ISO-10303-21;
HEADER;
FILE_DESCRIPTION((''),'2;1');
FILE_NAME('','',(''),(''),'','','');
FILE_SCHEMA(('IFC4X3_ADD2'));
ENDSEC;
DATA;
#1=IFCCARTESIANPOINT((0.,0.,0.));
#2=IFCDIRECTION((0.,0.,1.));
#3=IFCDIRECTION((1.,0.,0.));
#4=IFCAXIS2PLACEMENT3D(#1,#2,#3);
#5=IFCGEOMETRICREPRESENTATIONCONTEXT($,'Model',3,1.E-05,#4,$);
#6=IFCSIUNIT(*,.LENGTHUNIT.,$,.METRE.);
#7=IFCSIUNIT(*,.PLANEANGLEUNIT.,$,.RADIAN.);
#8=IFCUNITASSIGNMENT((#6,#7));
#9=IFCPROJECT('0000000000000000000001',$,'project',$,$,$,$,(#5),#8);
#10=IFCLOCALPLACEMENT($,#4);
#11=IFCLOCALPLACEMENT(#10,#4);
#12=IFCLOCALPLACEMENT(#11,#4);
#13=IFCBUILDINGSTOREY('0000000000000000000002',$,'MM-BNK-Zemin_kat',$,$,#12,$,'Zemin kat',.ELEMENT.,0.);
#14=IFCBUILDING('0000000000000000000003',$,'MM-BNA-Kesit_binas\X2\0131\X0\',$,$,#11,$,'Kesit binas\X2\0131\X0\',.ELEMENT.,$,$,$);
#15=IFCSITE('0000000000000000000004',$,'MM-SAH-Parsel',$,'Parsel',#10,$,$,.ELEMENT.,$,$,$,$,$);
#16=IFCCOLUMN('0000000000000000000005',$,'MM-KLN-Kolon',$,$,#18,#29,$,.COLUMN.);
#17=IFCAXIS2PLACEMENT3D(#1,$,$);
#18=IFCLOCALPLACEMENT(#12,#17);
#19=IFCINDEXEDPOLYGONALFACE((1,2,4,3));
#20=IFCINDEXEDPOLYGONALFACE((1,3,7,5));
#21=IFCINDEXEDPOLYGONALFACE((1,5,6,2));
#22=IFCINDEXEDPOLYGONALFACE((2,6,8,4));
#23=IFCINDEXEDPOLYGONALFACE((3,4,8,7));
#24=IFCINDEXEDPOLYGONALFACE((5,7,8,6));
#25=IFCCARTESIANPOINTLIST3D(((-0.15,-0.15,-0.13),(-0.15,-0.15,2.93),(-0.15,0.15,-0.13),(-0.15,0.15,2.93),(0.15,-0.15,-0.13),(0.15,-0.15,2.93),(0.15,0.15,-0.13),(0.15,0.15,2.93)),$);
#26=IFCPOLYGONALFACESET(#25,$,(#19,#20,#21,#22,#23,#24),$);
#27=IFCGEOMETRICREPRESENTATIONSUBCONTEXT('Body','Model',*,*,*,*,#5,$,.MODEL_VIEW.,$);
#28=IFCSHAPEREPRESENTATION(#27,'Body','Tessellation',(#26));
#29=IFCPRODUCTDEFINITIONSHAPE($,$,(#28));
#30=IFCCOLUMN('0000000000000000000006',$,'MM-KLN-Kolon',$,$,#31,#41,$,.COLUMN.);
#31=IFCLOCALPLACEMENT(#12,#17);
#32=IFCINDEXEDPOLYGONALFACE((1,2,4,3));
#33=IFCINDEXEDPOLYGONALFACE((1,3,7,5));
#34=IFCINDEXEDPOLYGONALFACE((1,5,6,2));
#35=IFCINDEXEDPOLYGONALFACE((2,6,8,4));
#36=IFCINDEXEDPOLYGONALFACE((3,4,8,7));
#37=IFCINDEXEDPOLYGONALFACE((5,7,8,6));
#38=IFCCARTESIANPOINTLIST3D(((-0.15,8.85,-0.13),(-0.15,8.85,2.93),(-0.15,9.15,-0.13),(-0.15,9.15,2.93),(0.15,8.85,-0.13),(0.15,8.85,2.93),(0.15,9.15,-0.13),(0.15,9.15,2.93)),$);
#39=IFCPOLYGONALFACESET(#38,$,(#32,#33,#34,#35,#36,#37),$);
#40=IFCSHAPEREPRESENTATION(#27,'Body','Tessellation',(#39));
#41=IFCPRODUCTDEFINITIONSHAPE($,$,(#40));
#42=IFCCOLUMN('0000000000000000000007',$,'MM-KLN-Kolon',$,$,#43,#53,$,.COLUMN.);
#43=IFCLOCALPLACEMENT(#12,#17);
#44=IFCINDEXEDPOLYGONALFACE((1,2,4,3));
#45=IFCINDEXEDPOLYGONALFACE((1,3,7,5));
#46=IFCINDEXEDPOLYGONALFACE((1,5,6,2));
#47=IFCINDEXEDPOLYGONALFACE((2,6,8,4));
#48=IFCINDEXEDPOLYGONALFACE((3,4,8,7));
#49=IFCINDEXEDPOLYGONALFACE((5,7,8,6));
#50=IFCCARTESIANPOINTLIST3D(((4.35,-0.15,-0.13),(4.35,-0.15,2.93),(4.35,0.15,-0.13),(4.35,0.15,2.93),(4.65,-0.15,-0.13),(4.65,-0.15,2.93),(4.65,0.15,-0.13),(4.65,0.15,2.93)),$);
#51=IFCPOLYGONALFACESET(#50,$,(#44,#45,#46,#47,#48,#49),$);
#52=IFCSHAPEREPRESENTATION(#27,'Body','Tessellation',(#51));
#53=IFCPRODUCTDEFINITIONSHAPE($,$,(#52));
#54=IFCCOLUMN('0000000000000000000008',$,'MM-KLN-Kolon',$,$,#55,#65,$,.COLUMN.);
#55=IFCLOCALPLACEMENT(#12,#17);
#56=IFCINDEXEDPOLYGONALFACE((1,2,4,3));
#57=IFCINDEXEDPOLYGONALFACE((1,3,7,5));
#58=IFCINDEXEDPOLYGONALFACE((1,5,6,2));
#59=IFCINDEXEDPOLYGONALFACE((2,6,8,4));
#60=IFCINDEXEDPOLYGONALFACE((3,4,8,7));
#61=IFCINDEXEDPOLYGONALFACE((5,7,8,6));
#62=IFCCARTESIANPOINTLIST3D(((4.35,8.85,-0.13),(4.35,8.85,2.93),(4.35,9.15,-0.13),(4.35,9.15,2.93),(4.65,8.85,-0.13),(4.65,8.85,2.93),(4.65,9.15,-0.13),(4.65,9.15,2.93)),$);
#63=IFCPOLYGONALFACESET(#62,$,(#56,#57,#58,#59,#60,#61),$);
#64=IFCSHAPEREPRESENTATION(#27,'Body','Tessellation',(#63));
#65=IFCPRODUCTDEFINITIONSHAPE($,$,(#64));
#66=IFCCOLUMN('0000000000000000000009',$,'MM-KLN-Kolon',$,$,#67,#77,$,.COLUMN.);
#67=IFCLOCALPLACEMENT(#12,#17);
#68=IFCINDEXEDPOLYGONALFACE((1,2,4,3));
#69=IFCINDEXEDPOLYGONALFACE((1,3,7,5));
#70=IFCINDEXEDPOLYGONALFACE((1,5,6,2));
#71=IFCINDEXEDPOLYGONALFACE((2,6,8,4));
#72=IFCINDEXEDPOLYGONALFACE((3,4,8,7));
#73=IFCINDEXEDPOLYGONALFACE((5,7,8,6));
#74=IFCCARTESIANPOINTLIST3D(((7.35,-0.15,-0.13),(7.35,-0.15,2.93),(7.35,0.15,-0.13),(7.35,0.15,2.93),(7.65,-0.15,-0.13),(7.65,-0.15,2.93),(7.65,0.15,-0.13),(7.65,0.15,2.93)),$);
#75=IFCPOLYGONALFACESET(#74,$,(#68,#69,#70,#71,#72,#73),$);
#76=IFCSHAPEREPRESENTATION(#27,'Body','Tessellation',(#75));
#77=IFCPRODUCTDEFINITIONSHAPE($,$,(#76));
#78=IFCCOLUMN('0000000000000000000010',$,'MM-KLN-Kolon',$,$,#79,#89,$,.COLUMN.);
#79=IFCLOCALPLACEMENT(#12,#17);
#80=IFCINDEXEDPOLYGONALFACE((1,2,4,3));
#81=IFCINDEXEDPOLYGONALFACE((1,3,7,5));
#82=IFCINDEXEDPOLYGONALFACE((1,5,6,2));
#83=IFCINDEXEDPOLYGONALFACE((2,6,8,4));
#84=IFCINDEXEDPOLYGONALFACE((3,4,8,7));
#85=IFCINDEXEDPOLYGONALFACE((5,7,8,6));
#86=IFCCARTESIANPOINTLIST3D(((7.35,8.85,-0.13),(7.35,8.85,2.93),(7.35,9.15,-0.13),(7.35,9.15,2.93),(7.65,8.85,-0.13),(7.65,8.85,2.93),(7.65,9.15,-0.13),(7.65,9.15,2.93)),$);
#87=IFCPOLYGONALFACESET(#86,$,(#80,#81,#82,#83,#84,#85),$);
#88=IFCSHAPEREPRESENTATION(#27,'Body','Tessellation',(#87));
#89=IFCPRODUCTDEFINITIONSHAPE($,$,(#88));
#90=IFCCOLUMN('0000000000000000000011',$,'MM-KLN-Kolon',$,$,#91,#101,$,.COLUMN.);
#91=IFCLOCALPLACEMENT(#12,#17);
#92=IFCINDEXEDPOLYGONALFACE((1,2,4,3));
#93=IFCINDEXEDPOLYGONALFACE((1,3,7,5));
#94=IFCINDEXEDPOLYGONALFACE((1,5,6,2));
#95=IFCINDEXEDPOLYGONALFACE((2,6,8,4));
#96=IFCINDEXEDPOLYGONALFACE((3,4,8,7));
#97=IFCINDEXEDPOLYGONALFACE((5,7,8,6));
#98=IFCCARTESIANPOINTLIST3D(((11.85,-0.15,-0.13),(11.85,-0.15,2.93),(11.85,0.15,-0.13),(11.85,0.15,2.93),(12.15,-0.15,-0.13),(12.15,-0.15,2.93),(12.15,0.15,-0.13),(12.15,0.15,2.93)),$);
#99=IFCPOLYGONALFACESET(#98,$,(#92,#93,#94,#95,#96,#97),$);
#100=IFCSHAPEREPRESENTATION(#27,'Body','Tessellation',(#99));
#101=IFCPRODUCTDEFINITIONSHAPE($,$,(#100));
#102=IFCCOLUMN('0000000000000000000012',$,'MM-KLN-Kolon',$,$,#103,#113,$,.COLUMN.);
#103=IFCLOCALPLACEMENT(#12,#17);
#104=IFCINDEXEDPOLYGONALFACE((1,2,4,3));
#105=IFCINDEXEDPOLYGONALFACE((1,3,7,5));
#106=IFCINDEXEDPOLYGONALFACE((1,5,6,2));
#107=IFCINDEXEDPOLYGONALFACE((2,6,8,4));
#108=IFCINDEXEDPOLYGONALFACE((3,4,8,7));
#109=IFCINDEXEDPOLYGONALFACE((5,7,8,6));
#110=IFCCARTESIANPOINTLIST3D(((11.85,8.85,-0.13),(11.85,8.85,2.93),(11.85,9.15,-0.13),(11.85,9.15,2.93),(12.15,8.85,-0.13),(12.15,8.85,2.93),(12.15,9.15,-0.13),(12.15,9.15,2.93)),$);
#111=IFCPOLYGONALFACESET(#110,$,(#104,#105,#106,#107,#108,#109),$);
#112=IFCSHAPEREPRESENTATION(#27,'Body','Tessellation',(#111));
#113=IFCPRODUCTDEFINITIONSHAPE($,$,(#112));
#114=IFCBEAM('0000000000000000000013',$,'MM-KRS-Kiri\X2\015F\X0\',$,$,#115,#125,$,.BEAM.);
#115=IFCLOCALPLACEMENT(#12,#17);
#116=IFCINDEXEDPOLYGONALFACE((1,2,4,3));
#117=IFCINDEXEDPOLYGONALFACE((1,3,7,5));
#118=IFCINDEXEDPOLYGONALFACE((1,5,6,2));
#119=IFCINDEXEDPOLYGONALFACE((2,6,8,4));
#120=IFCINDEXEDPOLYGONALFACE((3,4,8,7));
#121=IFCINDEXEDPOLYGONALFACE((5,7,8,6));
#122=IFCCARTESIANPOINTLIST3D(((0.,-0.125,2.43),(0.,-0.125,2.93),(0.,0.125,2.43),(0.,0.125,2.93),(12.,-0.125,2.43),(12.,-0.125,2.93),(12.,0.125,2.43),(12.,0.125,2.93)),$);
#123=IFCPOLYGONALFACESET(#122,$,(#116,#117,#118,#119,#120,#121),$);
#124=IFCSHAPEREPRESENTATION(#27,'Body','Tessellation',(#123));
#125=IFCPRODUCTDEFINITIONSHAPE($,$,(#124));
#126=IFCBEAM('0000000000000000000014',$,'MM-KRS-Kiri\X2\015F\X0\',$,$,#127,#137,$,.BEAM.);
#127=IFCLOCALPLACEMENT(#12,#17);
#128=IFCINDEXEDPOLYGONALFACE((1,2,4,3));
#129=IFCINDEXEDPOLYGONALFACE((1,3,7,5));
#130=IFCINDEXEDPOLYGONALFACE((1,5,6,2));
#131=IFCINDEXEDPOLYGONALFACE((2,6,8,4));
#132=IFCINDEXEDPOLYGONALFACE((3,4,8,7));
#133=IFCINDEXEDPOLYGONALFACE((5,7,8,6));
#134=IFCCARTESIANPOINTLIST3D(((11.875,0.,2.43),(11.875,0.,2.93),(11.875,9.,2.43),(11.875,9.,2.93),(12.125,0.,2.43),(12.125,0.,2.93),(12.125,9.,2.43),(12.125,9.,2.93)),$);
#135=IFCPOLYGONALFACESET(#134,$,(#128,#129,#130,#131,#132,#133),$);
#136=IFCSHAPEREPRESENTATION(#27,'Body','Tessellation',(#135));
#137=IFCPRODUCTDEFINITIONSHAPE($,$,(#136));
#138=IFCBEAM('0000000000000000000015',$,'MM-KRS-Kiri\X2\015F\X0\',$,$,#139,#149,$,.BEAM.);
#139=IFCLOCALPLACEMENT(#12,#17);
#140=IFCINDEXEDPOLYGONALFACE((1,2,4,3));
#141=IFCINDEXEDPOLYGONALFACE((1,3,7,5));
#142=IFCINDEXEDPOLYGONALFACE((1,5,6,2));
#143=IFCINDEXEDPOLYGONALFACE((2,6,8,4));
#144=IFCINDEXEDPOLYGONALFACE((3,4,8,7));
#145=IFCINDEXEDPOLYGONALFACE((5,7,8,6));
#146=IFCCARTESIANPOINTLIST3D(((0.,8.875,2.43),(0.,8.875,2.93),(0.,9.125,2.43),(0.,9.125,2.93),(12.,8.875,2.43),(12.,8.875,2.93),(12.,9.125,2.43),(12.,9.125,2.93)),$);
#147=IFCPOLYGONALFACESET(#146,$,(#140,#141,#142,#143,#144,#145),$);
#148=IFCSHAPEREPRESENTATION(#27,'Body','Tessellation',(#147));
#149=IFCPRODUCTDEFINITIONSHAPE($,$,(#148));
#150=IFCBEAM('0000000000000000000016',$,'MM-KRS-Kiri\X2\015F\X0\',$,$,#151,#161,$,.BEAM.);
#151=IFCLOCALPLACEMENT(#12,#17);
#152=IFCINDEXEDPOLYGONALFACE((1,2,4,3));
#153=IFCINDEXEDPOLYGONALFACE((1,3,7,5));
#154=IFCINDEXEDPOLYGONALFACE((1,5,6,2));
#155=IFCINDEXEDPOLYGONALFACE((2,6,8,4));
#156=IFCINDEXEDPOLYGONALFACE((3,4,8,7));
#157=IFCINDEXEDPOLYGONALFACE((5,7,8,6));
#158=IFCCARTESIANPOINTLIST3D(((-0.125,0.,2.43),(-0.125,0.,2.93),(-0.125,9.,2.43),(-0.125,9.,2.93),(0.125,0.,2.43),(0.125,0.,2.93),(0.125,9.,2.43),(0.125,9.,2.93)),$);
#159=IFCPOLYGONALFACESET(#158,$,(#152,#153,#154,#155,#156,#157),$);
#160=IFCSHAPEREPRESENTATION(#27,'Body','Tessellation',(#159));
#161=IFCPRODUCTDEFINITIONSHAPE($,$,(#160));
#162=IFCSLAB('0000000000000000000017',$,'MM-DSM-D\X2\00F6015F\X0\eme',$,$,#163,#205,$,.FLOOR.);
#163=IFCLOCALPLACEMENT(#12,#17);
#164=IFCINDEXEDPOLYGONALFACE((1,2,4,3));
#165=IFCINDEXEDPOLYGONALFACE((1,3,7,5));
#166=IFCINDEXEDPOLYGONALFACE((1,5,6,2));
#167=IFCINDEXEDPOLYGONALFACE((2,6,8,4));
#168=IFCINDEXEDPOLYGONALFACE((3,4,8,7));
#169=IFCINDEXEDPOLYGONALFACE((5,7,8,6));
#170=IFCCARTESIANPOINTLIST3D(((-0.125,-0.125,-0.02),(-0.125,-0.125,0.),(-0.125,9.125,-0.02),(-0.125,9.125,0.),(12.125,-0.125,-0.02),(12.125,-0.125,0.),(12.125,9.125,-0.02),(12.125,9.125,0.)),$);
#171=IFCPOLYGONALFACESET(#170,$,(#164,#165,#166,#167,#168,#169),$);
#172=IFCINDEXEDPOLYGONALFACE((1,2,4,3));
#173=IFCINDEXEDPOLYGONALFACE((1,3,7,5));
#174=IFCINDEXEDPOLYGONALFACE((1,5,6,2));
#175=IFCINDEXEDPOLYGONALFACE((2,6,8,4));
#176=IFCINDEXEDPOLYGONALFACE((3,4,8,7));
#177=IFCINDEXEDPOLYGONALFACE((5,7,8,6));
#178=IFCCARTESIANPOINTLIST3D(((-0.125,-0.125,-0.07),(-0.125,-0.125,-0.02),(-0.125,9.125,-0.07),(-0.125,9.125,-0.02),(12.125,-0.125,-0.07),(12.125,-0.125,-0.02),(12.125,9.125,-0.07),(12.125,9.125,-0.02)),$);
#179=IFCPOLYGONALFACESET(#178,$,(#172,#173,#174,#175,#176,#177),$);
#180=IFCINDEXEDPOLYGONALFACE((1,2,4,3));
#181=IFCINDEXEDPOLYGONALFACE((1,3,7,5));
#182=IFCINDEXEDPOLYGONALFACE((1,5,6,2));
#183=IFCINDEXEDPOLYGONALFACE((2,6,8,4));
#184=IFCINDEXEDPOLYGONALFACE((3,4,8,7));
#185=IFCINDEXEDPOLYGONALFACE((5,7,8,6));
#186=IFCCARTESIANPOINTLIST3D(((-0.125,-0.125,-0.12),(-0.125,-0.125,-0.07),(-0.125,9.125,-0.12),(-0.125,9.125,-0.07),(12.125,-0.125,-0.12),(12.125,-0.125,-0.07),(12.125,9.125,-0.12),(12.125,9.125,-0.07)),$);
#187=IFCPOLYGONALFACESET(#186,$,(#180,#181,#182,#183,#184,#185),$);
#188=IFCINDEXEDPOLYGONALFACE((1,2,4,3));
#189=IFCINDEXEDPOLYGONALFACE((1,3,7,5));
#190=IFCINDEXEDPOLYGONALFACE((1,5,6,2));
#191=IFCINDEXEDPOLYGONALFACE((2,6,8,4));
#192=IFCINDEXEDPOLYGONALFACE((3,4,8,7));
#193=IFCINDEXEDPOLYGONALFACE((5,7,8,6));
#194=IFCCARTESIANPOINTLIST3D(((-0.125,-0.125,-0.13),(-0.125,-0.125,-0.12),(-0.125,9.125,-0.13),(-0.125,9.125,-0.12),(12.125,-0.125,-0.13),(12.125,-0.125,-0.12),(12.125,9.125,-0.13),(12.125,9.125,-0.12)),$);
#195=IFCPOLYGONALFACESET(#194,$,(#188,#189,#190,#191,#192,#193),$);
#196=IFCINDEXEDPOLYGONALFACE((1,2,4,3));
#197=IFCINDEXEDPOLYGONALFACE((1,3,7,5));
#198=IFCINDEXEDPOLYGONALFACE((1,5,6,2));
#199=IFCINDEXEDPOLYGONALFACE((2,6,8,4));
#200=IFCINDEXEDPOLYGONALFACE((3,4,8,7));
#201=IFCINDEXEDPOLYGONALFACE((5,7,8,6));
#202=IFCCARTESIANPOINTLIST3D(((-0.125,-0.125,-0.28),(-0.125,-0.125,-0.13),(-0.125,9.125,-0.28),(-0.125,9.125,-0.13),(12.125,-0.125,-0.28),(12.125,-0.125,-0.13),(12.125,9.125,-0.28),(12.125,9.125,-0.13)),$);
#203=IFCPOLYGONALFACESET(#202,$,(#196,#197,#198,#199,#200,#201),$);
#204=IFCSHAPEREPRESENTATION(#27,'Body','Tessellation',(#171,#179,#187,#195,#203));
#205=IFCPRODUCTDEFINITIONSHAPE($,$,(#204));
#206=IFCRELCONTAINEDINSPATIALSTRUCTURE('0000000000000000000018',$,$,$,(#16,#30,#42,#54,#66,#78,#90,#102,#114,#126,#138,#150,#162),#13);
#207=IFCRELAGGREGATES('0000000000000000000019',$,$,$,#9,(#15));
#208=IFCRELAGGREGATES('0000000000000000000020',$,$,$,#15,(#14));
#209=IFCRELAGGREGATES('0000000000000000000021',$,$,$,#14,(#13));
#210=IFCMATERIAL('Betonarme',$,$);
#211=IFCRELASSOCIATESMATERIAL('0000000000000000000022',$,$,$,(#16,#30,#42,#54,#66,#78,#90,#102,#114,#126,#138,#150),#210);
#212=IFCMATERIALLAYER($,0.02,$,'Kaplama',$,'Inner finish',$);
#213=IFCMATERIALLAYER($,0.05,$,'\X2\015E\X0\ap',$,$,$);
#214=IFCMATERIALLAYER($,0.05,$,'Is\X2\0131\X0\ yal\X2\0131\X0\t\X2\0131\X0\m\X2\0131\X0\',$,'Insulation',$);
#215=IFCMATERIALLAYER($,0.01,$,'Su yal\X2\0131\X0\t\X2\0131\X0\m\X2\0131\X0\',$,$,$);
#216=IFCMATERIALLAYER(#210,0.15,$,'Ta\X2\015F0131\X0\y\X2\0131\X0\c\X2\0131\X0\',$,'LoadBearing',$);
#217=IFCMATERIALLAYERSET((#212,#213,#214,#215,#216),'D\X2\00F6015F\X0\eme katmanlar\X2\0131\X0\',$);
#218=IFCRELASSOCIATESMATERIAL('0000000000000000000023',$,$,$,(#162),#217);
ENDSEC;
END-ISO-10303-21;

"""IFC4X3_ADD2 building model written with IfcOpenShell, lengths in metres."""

from ifc_helpers import new_model, si_unit, frame, origin_with_axes, place, context, subcontext, project, spatial, polyline, outline, extrude, material, layer, layer_set, layer_usage, element, save


model = new_model("IFC4X3_ADD2")

# Units and contexts
model_context = context("Model", 3, precision=1e-05, world=origin_with_axes())
body_context = subcontext(model_context, "Body", "Model", "MODEL_VIEW")
ifc_project = project(units=[si_unit("LENGTHUNIT", "METRE"), si_unit("PLANEANGLEUNIT", "RADIAN")], contexts=[model_context])

# Site, building, storey
site_placement = place(None, origin_with_axes())
site = spatial("IfcSite", under=ifc_project, at=site_placement, Name="MM-SAH-Parsel", ObjectType="Parsel", CompositionType="ELEMENT")
building_placement = place(site_placement, origin_with_axes())
building = spatial("IfcBuilding", under=site, at=building_placement, Name="MM-BNA-Kesit_binası", LongName="Kesit binası", CompositionType="ELEMENT")
storey_placement = place(building_placement, origin_with_axes())
storey = spatial("IfcBuildingStorey", under=building, at=storey_placement, Name="MM-BNK-Zemin_kat", LongName="Zemin kat", CompositionType="ELEMENT", Elevation=0.0)

# Columns
ifc_material_1 = material(Name="Betonarme")
column_1_placement = place(storey_placement, origin_with_axes())
element("IfcColumn", 1, at=column_1_placement, inside=storey, material=ifc_material_1, Name="MM-KLN-Kolon", PredefinedType="COLUMN", context=body_context, shape_type="SweptSolid", body=[
    extrude(outline(polyline([(-0.15, -0.15), (0.15, -0.15), (0.15, 0.15), (-0.15, 0.15), (-0.15, -0.15)])), frame((0.0, 0.0, -0.13)), (0.0, 0.0, 1.0), 3.06),
])
column_2_placement = place(storey_placement, origin_with_axes())
element("IfcColumn", 2, at=column_2_placement, inside=storey, material=ifc_material_1, Name="MM-KLN-Kolon", PredefinedType="COLUMN", context=body_context, shape_type="SweptSolid", body=[
    extrude(outline(polyline([(-0.15, 8.85), (0.15, 8.85), (0.15, 9.15), (-0.15, 9.15), (-0.15, 8.85)])), frame((0.0, 0.0, -0.13)), (0.0, 0.0, 1.0), 3.06),
])
column_3_placement = place(storey_placement, origin_with_axes())
element("IfcColumn", 3, at=column_3_placement, inside=storey, material=ifc_material_1, Name="MM-KLN-Kolon", PredefinedType="COLUMN", context=body_context, shape_type="SweptSolid", body=[
    extrude(outline(polyline([(4.35, -0.15), (4.65, -0.15), (4.65, 0.15), (4.35, 0.15), (4.35, -0.15)])), frame((0.0, 0.0, -0.13)), (0.0, 0.0, 1.0), 3.06),
])
column_4_placement = place(storey_placement, origin_with_axes())
element("IfcColumn", 4, at=column_4_placement, inside=storey, material=ifc_material_1, Name="MM-KLN-Kolon", PredefinedType="COLUMN", context=body_context, shape_type="SweptSolid", body=[
    extrude(outline(polyline([(4.35, 8.85), (4.65, 8.85), (4.65, 9.15), (4.35, 9.15), (4.35, 8.85)])), frame((0.0, 0.0, -0.13)), (0.0, 0.0, 1.0), 3.06),
])
column_5_placement = place(storey_placement, origin_with_axes())
element("IfcColumn", 5, at=column_5_placement, inside=storey, material=ifc_material_1, Name="MM-KLN-Kolon", PredefinedType="COLUMN", context=body_context, shape_type="SweptSolid", body=[
    extrude(outline(polyline([(7.35, -0.15), (7.65, -0.15), (7.65, 0.15), (7.35, 0.15), (7.35, -0.15)])), frame((0.0, 0.0, -0.13)), (0.0, 0.0, 1.0), 3.06),
])
column_6_placement = place(storey_placement, origin_with_axes())
element("IfcColumn", 6, at=column_6_placement, inside=storey, material=ifc_material_1, Name="MM-KLN-Kolon", PredefinedType="COLUMN", context=body_context, shape_type="SweptSolid", body=[
    extrude(outline(polyline([(7.35, 8.85), (7.65, 8.85), (7.65, 9.15), (7.35, 9.15), (7.35, 8.85)])), frame((0.0, 0.0, -0.13)), (0.0, 0.0, 1.0), 3.06),
])
column_7_placement = place(storey_placement, origin_with_axes())
element("IfcColumn", 7, at=column_7_placement, inside=storey, material=ifc_material_1, Name="MM-KLN-Kolon", PredefinedType="COLUMN", context=body_context, shape_type="SweptSolid", body=[
    extrude(outline(polyline([(11.85, -0.15), (12.15, -0.15), (12.15, 0.15), (11.85, 0.15), (11.85, -0.15)])), frame((0.0, 0.0, -0.13)), (0.0, 0.0, 1.0), 3.06),
])
column_8_placement = place(storey_placement, origin_with_axes())
element("IfcColumn", 8, at=column_8_placement, inside=storey, material=ifc_material_1, Name="MM-KLN-Kolon", PredefinedType="COLUMN", context=body_context, shape_type="SweptSolid", body=[
    extrude(outline(polyline([(11.85, 8.85), (12.15, 8.85), (12.15, 9.15), (11.85, 9.15), (11.85, 8.85)])), frame((0.0, 0.0, -0.13)), (0.0, 0.0, 1.0), 3.06),
])

# Beams
beam_1_placement = place(storey_placement, origin_with_axes())
element("IfcBeam", 9, at=beam_1_placement, inside=storey, material=ifc_material_1, Name="MM-KRS-Kiriş", PredefinedType="BEAM", context=body_context, shape_type="SweptSolid", body=[
    extrude(outline(polyline([(0.0, 0.125), (12.0, 0.125), (12.0, -0.125), (0.0, -0.125), (0.0, 0.125)])), frame((0.0, 0.0, 2.43)), (0.0, 0.0, 1.0), 0.5),
])
beam_2_placement = place(storey_placement, origin_with_axes())
element("IfcBeam", 10, at=beam_2_placement, inside=storey, material=ifc_material_1, Name="MM-KRS-Kiriş", PredefinedType="BEAM", context=body_context, shape_type="SweptSolid", body=[
    extrude(outline(polyline([(11.875, 0.0), (11.875, 9.0), (12.125, 9.0), (12.125, 0.0), (11.875, 0.0)])), frame((0.0, 0.0, 2.43)), (0.0, 0.0, 1.0), 0.5),
])
beam_3_placement = place(storey_placement, origin_with_axes())
element("IfcBeam", 11, at=beam_3_placement, inside=storey, material=ifc_material_1, Name="MM-KRS-Kiriş", PredefinedType="BEAM", context=body_context, shape_type="SweptSolid", body=[
    extrude(outline(polyline([(12.0, 8.875), (0.0, 8.875), (0.0, 9.125), (12.0, 9.125), (12.0, 8.875)])), frame((0.0, 0.0, 2.43)), (0.0, 0.0, 1.0), 0.5),
])
beam_4_placement = place(storey_placement, origin_with_axes())
element("IfcBeam", 12, at=beam_4_placement, inside=storey, material=ifc_material_1, Name="MM-KRS-Kiriş", PredefinedType="BEAM", context=body_context, shape_type="SweptSolid", body=[
    extrude(outline(polyline([(0.125, 9.0), (0.125, 0.0), (-0.125, 0.0), (-0.125, 9.0), (0.125, 9.0)])), frame((0.0, 0.0, 2.43)), (0.0, 0.0, 1.0), 0.5),
])

# Slab
ifc_layer_1 = layer(None, 0.02, Name="Kaplama", Category="Inner finish")
ifc_layer_2 = layer(None, 0.05, Name="Şap")
ifc_layer_3 = layer(None, 0.05, Name="Isı yalıtımı", Category="Insulation")
ifc_layer_4 = layer(None, 0.01, Name="Su yalıtımı")
ifc_layer_5 = layer(ifc_material_1, 0.15, Name="Taşıyıcı", Category="LoadBearing")
ifc_layer_set_1 = layer_set([ifc_layer_1, ifc_layer_2, ifc_layer_3, ifc_layer_4, ifc_layer_5], Name="Döşeme katmanları")
ifc_layer_usage = layer_usage(ifc_layer_set_1, "AXIS3", "NEGATIVE", 0.0)
slab_placement = place(storey_placement, origin_with_axes())
element("IfcSlab", 13, at=slab_placement, inside=storey, material=ifc_layer_usage, Name="MM-DSM-Döşeme", PredefinedType="FLOOR", context=body_context, shape_type="SweptSolid", body=[
    extrude(outline(polyline([(-0.125, -0.125), (12.125, -0.125), (12.125, 9.125), (-0.125, 9.125), (-0.125, -0.125)])), frame((0.0, 0.0, -0.02)), (0.0, 0.0, 1.0), 0.02),
    extrude(outline(polyline([(-0.125, -0.125), (12.125, -0.125), (12.125, 9.125), (-0.125, 9.125), (-0.125, -0.125)])), frame((0.0, 0.0, -0.07)), (0.0, 0.0, 1.0), 0.05),
    extrude(outline(polyline([(-0.125, -0.125), (12.125, -0.125), (12.125, 9.125), (-0.125, 9.125), (-0.125, -0.125)])), frame((0.0, 0.0, -0.12)), (0.0, 0.0, 1.0), 0.05),
    extrude(outline(polyline([(-0.125, -0.125), (12.125, -0.125), (12.125, 9.125), (-0.125, 9.125), (-0.125, -0.125)])), frame((0.0, 0.0, -0.13)), (0.0, 0.0, 1.0), 0.01),
    extrude(outline(polyline([(-0.125, -0.125), (12.125, -0.125), (12.125, 9.125), (-0.125, 9.125), (-0.125, -0.125)])), frame((0.0, 0.0, -0.28)), (0.0, 0.0, 1.0), 0.15),
])

save(model, "model.ifc")
